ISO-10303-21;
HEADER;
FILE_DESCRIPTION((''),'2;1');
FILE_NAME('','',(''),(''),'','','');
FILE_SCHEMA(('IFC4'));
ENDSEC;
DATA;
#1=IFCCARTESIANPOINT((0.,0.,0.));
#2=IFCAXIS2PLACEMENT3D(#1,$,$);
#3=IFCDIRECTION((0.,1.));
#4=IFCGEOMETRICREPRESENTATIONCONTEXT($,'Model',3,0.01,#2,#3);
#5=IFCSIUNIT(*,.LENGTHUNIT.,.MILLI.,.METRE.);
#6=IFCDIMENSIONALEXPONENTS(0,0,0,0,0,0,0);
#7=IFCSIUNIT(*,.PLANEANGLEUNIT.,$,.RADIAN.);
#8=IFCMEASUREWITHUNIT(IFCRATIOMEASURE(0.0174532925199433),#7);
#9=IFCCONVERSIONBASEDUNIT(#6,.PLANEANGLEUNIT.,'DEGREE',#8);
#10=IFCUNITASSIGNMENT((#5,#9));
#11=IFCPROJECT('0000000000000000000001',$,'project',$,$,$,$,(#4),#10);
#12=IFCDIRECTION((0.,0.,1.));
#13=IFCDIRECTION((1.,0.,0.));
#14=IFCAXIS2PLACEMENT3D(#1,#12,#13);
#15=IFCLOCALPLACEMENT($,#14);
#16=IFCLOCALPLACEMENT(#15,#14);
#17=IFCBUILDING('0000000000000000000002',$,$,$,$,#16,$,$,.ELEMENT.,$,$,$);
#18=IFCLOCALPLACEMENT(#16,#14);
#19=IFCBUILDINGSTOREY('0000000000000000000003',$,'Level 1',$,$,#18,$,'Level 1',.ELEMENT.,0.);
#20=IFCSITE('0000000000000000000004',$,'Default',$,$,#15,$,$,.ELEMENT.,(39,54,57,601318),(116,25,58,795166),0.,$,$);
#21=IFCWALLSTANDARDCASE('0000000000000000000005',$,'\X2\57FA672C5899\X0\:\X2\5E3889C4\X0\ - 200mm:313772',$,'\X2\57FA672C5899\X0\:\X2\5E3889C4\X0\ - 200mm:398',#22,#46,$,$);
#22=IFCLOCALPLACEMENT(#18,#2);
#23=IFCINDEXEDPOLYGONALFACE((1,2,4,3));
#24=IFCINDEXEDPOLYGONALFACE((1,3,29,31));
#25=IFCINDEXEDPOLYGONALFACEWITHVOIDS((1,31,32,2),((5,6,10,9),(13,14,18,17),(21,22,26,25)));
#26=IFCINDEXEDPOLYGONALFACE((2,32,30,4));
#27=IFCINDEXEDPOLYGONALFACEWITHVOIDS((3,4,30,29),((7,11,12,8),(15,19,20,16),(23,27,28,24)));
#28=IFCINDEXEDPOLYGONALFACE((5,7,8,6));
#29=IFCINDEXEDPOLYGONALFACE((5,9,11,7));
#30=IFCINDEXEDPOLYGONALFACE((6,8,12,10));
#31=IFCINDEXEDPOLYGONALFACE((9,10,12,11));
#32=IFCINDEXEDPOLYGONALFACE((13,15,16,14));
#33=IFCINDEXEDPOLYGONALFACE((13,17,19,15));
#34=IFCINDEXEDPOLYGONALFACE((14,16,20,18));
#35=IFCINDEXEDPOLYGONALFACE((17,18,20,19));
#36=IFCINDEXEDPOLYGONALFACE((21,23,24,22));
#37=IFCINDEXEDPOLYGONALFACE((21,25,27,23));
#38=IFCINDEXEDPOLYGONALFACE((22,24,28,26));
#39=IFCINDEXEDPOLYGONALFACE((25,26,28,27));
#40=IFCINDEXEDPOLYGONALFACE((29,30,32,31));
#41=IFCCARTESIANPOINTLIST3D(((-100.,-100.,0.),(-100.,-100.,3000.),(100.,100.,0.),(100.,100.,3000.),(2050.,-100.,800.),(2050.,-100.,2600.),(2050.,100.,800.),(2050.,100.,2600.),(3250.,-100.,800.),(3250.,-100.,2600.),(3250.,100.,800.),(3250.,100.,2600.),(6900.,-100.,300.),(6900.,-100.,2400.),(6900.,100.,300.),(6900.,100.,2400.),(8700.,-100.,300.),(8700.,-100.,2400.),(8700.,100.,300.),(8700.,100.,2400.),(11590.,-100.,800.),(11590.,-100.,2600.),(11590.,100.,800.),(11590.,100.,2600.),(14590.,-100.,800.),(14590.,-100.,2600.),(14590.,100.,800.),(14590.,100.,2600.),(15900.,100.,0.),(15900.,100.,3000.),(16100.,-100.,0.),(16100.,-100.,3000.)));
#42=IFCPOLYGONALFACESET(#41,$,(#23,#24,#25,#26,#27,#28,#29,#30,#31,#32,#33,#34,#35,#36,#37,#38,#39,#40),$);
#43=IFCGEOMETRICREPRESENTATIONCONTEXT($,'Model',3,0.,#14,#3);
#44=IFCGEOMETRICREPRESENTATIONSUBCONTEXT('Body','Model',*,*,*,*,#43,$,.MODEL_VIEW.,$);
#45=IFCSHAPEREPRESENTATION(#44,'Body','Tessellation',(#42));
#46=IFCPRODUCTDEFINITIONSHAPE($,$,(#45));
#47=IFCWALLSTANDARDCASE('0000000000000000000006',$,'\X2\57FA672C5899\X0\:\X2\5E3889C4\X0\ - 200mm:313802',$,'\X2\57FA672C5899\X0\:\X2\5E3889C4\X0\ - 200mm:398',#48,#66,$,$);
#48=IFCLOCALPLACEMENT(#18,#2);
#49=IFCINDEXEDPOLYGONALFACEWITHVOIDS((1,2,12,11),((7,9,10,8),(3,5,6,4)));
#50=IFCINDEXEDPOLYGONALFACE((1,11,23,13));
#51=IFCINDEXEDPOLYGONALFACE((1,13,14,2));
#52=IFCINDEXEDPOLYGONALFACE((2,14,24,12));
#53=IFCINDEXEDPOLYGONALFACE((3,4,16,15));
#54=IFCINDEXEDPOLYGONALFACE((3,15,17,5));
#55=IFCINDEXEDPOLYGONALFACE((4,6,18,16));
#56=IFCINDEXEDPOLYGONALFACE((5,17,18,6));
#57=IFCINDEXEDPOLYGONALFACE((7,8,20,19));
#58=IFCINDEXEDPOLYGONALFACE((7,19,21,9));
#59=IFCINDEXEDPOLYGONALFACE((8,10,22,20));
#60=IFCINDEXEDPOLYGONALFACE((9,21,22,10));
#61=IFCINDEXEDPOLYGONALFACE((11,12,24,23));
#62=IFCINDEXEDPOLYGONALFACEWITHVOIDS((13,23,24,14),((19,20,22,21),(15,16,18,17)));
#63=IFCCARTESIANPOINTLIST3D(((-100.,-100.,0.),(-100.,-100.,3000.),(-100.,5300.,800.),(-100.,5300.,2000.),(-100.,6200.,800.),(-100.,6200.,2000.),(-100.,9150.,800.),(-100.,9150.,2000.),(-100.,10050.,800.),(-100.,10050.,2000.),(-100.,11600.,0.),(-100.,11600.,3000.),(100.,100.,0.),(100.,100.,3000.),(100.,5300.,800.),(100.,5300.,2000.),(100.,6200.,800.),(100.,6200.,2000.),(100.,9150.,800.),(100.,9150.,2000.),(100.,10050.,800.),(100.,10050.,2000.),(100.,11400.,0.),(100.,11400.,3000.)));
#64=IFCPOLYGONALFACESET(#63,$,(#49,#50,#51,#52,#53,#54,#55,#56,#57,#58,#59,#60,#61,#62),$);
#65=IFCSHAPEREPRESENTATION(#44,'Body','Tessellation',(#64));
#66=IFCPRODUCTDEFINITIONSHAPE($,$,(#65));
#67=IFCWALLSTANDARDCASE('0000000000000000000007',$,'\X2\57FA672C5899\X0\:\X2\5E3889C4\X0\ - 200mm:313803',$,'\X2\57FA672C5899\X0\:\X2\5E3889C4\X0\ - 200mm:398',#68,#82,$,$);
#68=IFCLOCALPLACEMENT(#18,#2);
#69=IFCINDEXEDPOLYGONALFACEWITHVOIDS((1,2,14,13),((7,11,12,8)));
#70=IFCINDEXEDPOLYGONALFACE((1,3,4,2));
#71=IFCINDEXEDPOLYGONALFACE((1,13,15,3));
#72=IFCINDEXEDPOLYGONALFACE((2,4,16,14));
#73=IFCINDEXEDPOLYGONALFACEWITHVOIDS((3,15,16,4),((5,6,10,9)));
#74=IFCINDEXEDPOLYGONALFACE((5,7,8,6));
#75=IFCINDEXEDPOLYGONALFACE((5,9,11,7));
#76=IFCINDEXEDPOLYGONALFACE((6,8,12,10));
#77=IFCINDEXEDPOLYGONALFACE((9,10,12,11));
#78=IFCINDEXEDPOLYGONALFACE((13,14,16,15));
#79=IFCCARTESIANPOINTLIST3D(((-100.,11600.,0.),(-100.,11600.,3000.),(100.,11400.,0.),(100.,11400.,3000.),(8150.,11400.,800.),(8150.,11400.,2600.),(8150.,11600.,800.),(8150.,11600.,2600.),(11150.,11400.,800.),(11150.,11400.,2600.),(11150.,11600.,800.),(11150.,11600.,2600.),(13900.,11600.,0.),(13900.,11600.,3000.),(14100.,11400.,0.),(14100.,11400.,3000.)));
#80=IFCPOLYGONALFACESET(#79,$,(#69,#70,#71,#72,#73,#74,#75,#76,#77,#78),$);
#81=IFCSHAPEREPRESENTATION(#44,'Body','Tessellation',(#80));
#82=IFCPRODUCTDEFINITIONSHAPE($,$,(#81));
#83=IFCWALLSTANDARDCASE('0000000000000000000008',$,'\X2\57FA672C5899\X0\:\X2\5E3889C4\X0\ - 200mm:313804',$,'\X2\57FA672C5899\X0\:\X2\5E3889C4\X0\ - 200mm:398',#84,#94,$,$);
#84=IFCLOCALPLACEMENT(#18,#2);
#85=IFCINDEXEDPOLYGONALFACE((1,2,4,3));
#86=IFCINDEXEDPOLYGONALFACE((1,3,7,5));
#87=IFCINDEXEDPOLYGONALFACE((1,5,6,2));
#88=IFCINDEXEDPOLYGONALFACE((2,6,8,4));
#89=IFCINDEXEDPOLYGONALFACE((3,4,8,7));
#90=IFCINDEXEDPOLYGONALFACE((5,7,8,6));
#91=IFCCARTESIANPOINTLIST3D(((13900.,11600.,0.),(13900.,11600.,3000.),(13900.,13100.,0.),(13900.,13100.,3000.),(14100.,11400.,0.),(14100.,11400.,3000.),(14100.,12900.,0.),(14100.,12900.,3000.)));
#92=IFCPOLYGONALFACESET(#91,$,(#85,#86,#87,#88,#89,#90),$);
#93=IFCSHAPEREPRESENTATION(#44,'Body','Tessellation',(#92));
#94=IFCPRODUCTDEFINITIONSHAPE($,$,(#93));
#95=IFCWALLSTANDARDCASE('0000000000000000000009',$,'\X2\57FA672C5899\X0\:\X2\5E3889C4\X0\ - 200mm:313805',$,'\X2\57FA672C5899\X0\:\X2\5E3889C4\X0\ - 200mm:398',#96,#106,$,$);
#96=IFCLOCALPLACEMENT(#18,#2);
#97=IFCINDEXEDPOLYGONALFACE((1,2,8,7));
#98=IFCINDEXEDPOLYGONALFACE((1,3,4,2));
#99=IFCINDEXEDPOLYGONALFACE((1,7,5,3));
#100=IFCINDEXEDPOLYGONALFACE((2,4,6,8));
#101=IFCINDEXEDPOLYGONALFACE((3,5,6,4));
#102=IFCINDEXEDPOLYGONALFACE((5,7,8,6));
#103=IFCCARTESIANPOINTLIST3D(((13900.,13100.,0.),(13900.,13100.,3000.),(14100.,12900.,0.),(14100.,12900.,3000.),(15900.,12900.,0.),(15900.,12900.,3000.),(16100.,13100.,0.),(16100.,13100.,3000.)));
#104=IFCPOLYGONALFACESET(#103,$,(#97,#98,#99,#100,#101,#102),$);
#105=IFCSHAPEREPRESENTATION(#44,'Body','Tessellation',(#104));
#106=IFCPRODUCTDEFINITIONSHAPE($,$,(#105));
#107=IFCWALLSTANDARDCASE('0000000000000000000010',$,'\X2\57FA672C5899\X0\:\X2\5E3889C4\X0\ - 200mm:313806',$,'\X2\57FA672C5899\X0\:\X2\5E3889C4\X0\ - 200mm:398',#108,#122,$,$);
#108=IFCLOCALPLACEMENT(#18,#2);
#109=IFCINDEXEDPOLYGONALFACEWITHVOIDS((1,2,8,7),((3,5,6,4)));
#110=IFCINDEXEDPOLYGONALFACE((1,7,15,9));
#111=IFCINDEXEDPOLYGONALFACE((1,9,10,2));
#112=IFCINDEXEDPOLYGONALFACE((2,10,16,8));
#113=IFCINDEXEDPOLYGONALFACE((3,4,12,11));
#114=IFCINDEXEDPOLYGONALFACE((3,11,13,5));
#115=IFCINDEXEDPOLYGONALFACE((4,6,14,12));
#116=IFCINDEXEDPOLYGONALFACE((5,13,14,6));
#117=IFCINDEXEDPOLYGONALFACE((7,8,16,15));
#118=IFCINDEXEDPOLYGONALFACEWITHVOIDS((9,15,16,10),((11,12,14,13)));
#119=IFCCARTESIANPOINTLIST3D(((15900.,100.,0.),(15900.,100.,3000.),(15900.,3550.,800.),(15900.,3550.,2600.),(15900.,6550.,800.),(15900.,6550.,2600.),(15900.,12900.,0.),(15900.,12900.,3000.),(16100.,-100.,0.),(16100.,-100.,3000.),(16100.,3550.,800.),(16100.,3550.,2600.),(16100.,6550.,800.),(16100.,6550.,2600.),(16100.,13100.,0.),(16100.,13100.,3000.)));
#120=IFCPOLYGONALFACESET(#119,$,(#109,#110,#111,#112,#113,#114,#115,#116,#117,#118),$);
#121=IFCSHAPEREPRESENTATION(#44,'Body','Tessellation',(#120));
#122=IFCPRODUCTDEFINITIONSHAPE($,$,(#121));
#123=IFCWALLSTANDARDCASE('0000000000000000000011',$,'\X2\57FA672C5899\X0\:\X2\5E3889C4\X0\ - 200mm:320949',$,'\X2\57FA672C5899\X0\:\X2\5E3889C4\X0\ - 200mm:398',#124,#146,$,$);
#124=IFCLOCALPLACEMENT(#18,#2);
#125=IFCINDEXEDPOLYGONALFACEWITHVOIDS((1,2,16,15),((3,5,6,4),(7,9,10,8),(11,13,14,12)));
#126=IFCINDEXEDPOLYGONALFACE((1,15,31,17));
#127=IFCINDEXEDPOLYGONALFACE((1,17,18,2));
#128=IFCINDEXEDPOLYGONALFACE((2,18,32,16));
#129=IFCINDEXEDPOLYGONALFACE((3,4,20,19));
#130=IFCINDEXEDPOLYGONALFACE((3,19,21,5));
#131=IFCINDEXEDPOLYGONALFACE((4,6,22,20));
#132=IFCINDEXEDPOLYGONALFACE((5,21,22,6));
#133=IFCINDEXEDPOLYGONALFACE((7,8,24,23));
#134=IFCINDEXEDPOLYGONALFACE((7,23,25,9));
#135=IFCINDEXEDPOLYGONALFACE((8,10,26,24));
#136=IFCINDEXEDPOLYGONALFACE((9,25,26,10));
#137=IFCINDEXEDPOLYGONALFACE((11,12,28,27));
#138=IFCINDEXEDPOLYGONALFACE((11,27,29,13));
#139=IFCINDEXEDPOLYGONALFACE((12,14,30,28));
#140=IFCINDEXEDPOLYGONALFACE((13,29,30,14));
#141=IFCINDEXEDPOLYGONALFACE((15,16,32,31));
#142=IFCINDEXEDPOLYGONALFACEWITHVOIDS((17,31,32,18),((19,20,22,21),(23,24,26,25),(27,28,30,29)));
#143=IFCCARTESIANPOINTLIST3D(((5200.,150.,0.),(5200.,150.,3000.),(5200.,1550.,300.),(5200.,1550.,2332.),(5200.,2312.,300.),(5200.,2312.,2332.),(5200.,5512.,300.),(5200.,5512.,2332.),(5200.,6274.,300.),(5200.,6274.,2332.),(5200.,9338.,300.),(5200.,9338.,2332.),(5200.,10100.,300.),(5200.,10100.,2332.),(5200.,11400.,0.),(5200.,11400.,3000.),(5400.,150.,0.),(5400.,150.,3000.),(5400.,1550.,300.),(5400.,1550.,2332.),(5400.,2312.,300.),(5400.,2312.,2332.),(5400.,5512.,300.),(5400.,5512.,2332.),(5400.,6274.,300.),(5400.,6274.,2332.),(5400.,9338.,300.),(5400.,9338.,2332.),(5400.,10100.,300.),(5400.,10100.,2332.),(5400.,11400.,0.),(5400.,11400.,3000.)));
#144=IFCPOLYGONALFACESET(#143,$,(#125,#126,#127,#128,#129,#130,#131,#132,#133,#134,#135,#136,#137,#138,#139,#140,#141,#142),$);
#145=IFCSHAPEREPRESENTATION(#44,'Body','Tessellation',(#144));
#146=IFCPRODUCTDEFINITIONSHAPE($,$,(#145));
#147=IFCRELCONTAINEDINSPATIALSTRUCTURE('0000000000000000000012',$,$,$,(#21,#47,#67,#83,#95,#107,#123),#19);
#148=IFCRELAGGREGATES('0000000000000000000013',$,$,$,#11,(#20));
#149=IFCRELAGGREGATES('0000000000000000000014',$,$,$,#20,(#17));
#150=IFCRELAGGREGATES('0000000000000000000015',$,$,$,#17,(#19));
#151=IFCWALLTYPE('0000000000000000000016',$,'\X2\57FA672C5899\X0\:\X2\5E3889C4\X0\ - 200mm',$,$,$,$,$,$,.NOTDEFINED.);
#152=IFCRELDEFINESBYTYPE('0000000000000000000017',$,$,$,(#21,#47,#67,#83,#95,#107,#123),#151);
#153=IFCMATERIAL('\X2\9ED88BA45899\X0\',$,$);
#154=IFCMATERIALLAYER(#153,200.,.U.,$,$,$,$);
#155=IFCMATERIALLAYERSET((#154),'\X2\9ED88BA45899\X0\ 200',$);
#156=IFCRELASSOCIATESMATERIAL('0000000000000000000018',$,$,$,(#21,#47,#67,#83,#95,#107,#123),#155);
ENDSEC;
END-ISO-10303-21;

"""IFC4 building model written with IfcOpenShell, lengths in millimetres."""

from ifc_helpers import new_model, entity, si_unit, converted_unit, direction, frame, origin, origin_with_axes, place, context, subcontext, project, spatial, polyline, outline, extrude, material, layer, layer_set, layer_usage, type_object, element, save


model = new_model("IFC4")

# Units and contexts
model_context_1 = context("Model", 3, precision=0.01, world=origin(), true_north=direction((0.0, 1.0)))
model_context_2 = context("Model", 3, precision=0.0, world=origin_with_axes(), true_north=direction((0.0, 1.0)))
body_context = subcontext(model_context_2, "Body", "Model", "MODEL_VIEW")
ifc_project = project(units=[si_unit("LENGTHUNIT", "METRE", prefix="MILLI"), converted_unit("PLANEANGLEUNIT", "DEGREE", entity("IfcRatioMeasure", 0.0174532925199433), si_unit("PLANEANGLEUNIT", "RADIAN"), dimensions=[0, 0, 0, 0, 0, 0, 0])], contexts=[model_context_1])

# Site, building, storey
site_placement = place(None, origin_with_axes())
site = spatial("IfcSite", under=ifc_project, at=site_placement, Name="Default", CompositionType="ELEMENT", RefLatitude=(39, 54, 57, 601318), RefLongitude=(116, 25, 58, 795166), RefElevation=0.0)
building_placement = place(site_placement, origin_with_axes())
building = spatial("IfcBuilding", under=site, at=building_placement, CompositionType="ELEMENT")
storey_placement = place(building_placement, origin_with_axes())
storey = spatial("IfcBuildingStorey", under=building, at=storey_placement, Name="Level 1", LongName="Level 1", CompositionType="ELEMENT", Elevation=0.0)

# Walls, openings
ifc_material = material(Name="默认墙")
ifc_layer = layer(ifc_material, 200.0, ventilated="UNKNOWN")
ifc_layer_set = layer_set([ifc_layer], Name="默认墙 200")
ifc_layer_usage_1 = layer_usage(ifc_layer_set, "AXIS2", "POSITIVE", -100.0)
wall_type = type_object("IfcWallType", Name="基本墙:常规 - 200mm", PredefinedType="NOTDEFINED")
wall_1_placement = place(storey_placement, frame((16000.0, 0.0, 0.0), z_axis=(0.0, 0.0, 1.0), x_axis=(-1.0, 0.0, 0.0)))
wall_1 = element("IfcWallStandardCase", 1, at=wall_1_placement, inside=storey, type_object=wall_type, material=ifc_layer_usage_1, Name="基本墙:常规 - 200mm:313772", ObjectType="基本墙:常规 - 200mm:398", context=body_context, shape_type="SweptSolid", body=[
    extrude(outline(polyline([(100.0, -100.0), (15900.0, -100.0), (16100.0, 100.0), (-100.0, 100.0), (100.0, -100.0)])), origin_with_axes(), (0.0, 0.0, 1.0), 3000.0),
])
opening_1_placement = place(wall_1_placement, frame((13350.0, 0.0, 800.0), z_axis=(0.0, 0.0, 1.0), x_axis=(1.0, 0.0, 0.0)))
element("IfcOpeningElement", 2, at=opening_1_placement, cuts=wall_1, context=body_context, shape_type="SweptSolid", body=[
    extrude(outline(polyline([(-600.0, 0.0), (-600.0, -1800.0), (600.0, -1800.0), (600.0, 0.0), (-600.0, 0.0)])), frame((0.0, -100.0, 0.0), z_axis=(0.0, 1.0, 0.0), x_axis=(1.0, 0.0, 0.0)), (0.0, 0.0, 1.0), 200.0),
])
opening_2_placement = place(wall_1_placement, frame((2910.0, 0.0, 800.0), z_axis=(0.0, 0.0, 1.0), x_axis=(1.0, 0.0, 0.0)))
element("IfcOpeningElement", 3, at=opening_2_placement, cuts=wall_1, context=body_context, shape_type="SweptSolid", body=[
    extrude(outline(polyline([(-1500.0, 0.0), (-1500.0, -1800.0), (1500.0, -1800.0), (1500.0, 0.0), (-1500.0, 0.0)])), frame((0.0, -100.0, 0.0), z_axis=(0.0, 1.0, 0.0), x_axis=(1.0, 0.0, 0.0)), (0.0, 0.0, 1.0), 200.0),
])
opening_3_placement = place(wall_1_placement, frame((8200.0, 0.0, 300.0), z_axis=(0.0, 0.0, 1.0), x_axis=(1.0, 0.0, 0.0)))
element("IfcOpeningElement", 4, at=opening_3_placement, cuts=wall_1, context=body_context, shape_type="SweptSolid", body=[
    extrude(outline(polyline([(-900.0, 0.0), (-900.0, -2100.0), (900.0, -2100.0), (900.0, 0.0), (-900.0, 0.0)])), frame((0.0, -100.0, 0.0), z_axis=(0.0, 1.0, 0.0), x_axis=(1.0, 0.0, 0.0)), (0.0, 0.0, 1.0), 200.0),
])
ifc_layer_usage_2 = layer_usage(ifc_layer_set, "AXIS2", "POSITIVE", -100.0)
wall_2_placement = place(storey_placement, frame((0.0, 0.0, 0.0), z_axis=(0.0, 0.0, 1.0), x_axis=(0.0, 1.0, 0.0)))
wall_2 = element("IfcWallStandardCase", 5, at=wall_2_placement, inside=storey, type_object=wall_type, material=ifc_layer_usage_2, Name="基本墙:常规 - 200mm:313802", ObjectType="基本墙:常规 - 200mm:398", context=body_context, shape_type="SweptSolid", body=[
    extrude(outline(polyline([(100.0, -100.0), (11400.0, -100.0), (11600.0, 100.0), (-100.0, 100.0), (100.0, -100.0)])), origin_with_axes(), (0.0, 0.0, 1.0), 3000.0),
])
opening_4_placement = place(wall_2_placement, frame((5750.0, 0.0, 800.0), z_axis=(0.0, 0.0, 1.0), x_axis=(1.0, 0.0, 0.0)))
element("IfcOpeningElement", 6, at=opening_4_placement, cuts=wall_2, context=body_context, shape_type="SweptSolid", body=[
    extrude(outline(polyline([(450.0, -1200.0), (450.0, 0.0), (-450.0, 0.0), (-450.0, -1200.0), (450.0, -1200.0)])), frame((0.0, 100.0, 0.0), z_axis=(0.0, -1.0, 0.0), x_axis=(-1.0, 0.0, 0.0)), (0.0, 0.0, 1.0), 200.0),
])
opening_5_placement = place(wall_2_placement, frame((9600.0, 0.0, 800.0), z_axis=(0.0, 0.0, 1.0), x_axis=(1.0, 0.0, 0.0)))
element("IfcOpeningElement", 7, at=opening_5_placement, cuts=wall_2, context=body_context, shape_type="SweptSolid", body=[
    extrude(outline(polyline([(450.0, -1200.0), (450.0, 0.0), (-450.0, 0.0), (-450.0, -1200.0), (450.0, -1200.0)])), frame((0.0, 100.0, 0.0), z_axis=(0.0, -1.0, 0.0), x_axis=(-1.0, 0.0, 0.0)), (0.0, 0.0, 1.0), 200.0),
])

# Wall, opening
ifc_layer_usage_3 = layer_usage(ifc_layer_set, "AXIS2", "POSITIVE", -100.0)
wall_3_placement = place(storey_placement, frame((0.0, 11500.0, 0.0), z_axis=(0.0, 0.0, 1.0), x_axis=(1.0, 0.0, 0.0)))
wall_3 = element("IfcWallStandardCase", 8, at=wall_3_placement, inside=storey, type_object=wall_type, material=ifc_layer_usage_3, Name="基本墙:常规 - 200mm:313803", ObjectType="基本墙:常规 - 200mm:398", context=body_context, shape_type="SweptSolid", body=[
    extrude(outline(polyline([(100.0, -100.0), (14100.0, -100.0), (13900.0, 100.0), (-100.0, 100.0), (100.0, -100.0)])), origin_with_axes(), (0.0, 0.0, 1.0), 3000.0),
])
opening_6_placement = place(wall_3_placement, frame((9650.0, 0.0, 800.0), z_axis=(0.0, 0.0, 1.0), x_axis=(1.0, 0.0, 0.0)))
element("IfcOpeningElement", 9, at=opening_6_placement, cuts=wall_3, context=body_context, shape_type="SweptSolid", body=[
    extrude(outline(polyline([(-1500.0, 0.0), (-1500.0, -1800.0), (1500.0, -1800.0), (1500.0, 0.0), (-1500.0, 0.0)])), frame((0.0, -100.0, 0.0), z_axis=(0.0, 1.0, 0.0), x_axis=(1.0, 0.0, 0.0)), (0.0, 0.0, 1.0), 200.0),
])

# Walls
ifc_layer_usage_4 = layer_usage(ifc_layer_set, "AXIS2", "POSITIVE", -100.0)
wall_4_placement = place(storey_placement, frame((14000.0, 11500.0, 0.0), z_axis=(0.0, 0.0, 1.0), x_axis=(0.0, 1.0, 0.0)))
element("IfcWallStandardCase", 10, at=wall_4_placement, inside=storey, type_object=wall_type, material=ifc_layer_usage_4, Name="基本墙:常规 - 200mm:313804", ObjectType="基本墙:常规 - 200mm:398", context=body_context, shape_type="SweptSolid", body=[
    extrude(outline(polyline([(-100.0, -100.0), (1400.0, -100.0), (1600.0, 100.0), (100.0, 100.0), (-100.0, -100.0)])), origin_with_axes(), (0.0, 0.0, 1.0), 3000.0),
])
ifc_layer_usage_5 = layer_usage(ifc_layer_set, "AXIS2", "POSITIVE", -100.0)
wall_5_placement = place(storey_placement, frame((14000.0, 13000.0, 0.0), z_axis=(0.0, 0.0, 1.0), x_axis=(1.0, 0.0, 0.0)))
element("IfcWallStandardCase", 11, at=wall_5_placement, inside=storey, type_object=wall_type, material=ifc_layer_usage_5, Name="基本墙:常规 - 200mm:313805", ObjectType="基本墙:常规 - 200mm:398", context=body_context, shape_type="SweptSolid", body=[
    extrude(outline(polyline([(100.0, -100.0), (1900.0, -100.0), (2100.0, 100.0), (-100.0, 100.0), (100.0, -100.0)])), origin_with_axes(), (0.0, 0.0, 1.0), 3000.0),
])

# Wall, opening
ifc_layer_usage_6 = layer_usage(ifc_layer_set, "AXIS2", "POSITIVE", -100.0)
wall_6_placement = place(storey_placement, frame((16000.0, 13000.0, 0.0), z_axis=(0.0, 0.0, 1.0), x_axis=(0.0, -1.0, 0.0)))
wall_6 = element("IfcWallStandardCase", 12, at=wall_6_placement, inside=storey, type_object=wall_type, material=ifc_layer_usage_6, Name="基本墙:常规 - 200mm:313806", ObjectType="基本墙:常规 - 200mm:398", context=body_context, shape_type="SweptSolid", body=[
    extrude(outline(polyline([(100.0, -100.0), (12900.0, -100.0), (13100.0, 100.0), (-100.0, 100.0), (100.0, -100.0)])), origin_with_axes(), (0.0, 0.0, 1.0), 3000.0),
])
opening_7_placement = place(wall_6_placement, frame((7950.0, 0.0, 800.0), z_axis=(0.0, 0.0, 1.0), x_axis=(1.0, 0.0, 0.0)))
element("IfcOpeningElement", 13, at=opening_7_placement, cuts=wall_6, context=body_context, shape_type="SweptSolid", body=[
    extrude(outline(polyline([(-1500.0, 0.0), (-1500.0, -1800.0), (1500.0, -1800.0), (1500.0, 0.0), (-1500.0, 0.0)])), frame((0.0, -100.0, 0.0), z_axis=(0.0, 1.0, 0.0), x_axis=(1.0, 0.0, 0.0)), (0.0, 0.0, 1.0), 200.0),
])

# Wall, openings
ifc_layer_usage_7 = layer_usage(ifc_layer_set, "AXIS2", "POSITIVE", -100.0)
wall_7_placement = place(storey_placement, frame((5300.0, 11500.0, 0.0), z_axis=(0.0, 0.0, 1.0), x_axis=(0.0, -1.0, 0.0)))
wall_7 = element("IfcWallStandardCase", 14, at=wall_7_placement, inside=storey, type_object=wall_type, material=ifc_layer_usage_7, Name="基本墙:常规 - 200mm:320949", ObjectType="基本墙:常规 - 200mm:398", context=body_context, shape_type="SweptSolid", body=[
    extrude(outline(polyline([(100.0, -100.0), (11350.0, -100.0), (11350.0, 100.0), (100.0, 100.0), (100.0, -100.0)])), origin_with_axes(), (0.0, 0.0, 1.0), 3000.0),
])
opening_8_placement = place(wall_7_placement, frame((9569.0, 0.0, 300.0), z_axis=(0.0, 0.0, 1.0), x_axis=(1.0, 0.0, 0.0)))
element("IfcOpeningElement", 15, at=opening_8_placement, cuts=wall_7, context=body_context, shape_type="SweptSolid", body=[
    extrude(outline(polyline([(-381.0, -2032.0), (381.0, -2032.0), (381.0, 0.0), (-381.0, 0.0), (-381.0, -2032.0)])), frame((0.0, -100.0, 0.0), z_axis=(0.0, 1.0, 0.0), x_axis=(1.0, 0.0, 0.0)), (0.0, 0.0, 1.0), 200.0),
])
opening_9_placement = place(wall_7_placement, frame((5607.0, 0.0, 300.0), z_axis=(0.0, 0.0, 1.0), x_axis=(1.0, 0.0, 0.0)))
element("IfcOpeningElement", 16, at=opening_9_placement, cuts=wall_7, context=body_context, shape_type="SweptSolid", body=[
    extrude(outline(polyline([(-381.0, -2032.0), (381.0, -2032.0), (381.0, 0.0), (-381.0, 0.0), (-381.0, -2032.0)])), frame((0.0, -100.0, 0.0), z_axis=(0.0, 1.0, 0.0), x_axis=(1.0, 0.0, 0.0)), (0.0, 0.0, 1.0), 200.0),
])
opening_10_placement = place(wall_7_placement, frame((1781.0, 0.0, 300.0), z_axis=(0.0, 0.0, 1.0), x_axis=(1.0, 0.0, 0.0)))
element("IfcOpeningElement", 17, at=opening_10_placement, cuts=wall_7, context=body_context, shape_type="SweptSolid", body=[
    extrude(outline(polyline([(-381.0, -2032.0), (381.0, -2032.0), (381.0, 0.0), (-381.0, 0.0), (-381.0, -2032.0)])), frame((0.0, -100.0, 0.0), z_axis=(0.0, 1.0, 0.0), x_axis=(1.0, 0.0, 0.0)), (0.0, 0.0, 1.0), 200.0),
])

save(model, "model.ifc")
